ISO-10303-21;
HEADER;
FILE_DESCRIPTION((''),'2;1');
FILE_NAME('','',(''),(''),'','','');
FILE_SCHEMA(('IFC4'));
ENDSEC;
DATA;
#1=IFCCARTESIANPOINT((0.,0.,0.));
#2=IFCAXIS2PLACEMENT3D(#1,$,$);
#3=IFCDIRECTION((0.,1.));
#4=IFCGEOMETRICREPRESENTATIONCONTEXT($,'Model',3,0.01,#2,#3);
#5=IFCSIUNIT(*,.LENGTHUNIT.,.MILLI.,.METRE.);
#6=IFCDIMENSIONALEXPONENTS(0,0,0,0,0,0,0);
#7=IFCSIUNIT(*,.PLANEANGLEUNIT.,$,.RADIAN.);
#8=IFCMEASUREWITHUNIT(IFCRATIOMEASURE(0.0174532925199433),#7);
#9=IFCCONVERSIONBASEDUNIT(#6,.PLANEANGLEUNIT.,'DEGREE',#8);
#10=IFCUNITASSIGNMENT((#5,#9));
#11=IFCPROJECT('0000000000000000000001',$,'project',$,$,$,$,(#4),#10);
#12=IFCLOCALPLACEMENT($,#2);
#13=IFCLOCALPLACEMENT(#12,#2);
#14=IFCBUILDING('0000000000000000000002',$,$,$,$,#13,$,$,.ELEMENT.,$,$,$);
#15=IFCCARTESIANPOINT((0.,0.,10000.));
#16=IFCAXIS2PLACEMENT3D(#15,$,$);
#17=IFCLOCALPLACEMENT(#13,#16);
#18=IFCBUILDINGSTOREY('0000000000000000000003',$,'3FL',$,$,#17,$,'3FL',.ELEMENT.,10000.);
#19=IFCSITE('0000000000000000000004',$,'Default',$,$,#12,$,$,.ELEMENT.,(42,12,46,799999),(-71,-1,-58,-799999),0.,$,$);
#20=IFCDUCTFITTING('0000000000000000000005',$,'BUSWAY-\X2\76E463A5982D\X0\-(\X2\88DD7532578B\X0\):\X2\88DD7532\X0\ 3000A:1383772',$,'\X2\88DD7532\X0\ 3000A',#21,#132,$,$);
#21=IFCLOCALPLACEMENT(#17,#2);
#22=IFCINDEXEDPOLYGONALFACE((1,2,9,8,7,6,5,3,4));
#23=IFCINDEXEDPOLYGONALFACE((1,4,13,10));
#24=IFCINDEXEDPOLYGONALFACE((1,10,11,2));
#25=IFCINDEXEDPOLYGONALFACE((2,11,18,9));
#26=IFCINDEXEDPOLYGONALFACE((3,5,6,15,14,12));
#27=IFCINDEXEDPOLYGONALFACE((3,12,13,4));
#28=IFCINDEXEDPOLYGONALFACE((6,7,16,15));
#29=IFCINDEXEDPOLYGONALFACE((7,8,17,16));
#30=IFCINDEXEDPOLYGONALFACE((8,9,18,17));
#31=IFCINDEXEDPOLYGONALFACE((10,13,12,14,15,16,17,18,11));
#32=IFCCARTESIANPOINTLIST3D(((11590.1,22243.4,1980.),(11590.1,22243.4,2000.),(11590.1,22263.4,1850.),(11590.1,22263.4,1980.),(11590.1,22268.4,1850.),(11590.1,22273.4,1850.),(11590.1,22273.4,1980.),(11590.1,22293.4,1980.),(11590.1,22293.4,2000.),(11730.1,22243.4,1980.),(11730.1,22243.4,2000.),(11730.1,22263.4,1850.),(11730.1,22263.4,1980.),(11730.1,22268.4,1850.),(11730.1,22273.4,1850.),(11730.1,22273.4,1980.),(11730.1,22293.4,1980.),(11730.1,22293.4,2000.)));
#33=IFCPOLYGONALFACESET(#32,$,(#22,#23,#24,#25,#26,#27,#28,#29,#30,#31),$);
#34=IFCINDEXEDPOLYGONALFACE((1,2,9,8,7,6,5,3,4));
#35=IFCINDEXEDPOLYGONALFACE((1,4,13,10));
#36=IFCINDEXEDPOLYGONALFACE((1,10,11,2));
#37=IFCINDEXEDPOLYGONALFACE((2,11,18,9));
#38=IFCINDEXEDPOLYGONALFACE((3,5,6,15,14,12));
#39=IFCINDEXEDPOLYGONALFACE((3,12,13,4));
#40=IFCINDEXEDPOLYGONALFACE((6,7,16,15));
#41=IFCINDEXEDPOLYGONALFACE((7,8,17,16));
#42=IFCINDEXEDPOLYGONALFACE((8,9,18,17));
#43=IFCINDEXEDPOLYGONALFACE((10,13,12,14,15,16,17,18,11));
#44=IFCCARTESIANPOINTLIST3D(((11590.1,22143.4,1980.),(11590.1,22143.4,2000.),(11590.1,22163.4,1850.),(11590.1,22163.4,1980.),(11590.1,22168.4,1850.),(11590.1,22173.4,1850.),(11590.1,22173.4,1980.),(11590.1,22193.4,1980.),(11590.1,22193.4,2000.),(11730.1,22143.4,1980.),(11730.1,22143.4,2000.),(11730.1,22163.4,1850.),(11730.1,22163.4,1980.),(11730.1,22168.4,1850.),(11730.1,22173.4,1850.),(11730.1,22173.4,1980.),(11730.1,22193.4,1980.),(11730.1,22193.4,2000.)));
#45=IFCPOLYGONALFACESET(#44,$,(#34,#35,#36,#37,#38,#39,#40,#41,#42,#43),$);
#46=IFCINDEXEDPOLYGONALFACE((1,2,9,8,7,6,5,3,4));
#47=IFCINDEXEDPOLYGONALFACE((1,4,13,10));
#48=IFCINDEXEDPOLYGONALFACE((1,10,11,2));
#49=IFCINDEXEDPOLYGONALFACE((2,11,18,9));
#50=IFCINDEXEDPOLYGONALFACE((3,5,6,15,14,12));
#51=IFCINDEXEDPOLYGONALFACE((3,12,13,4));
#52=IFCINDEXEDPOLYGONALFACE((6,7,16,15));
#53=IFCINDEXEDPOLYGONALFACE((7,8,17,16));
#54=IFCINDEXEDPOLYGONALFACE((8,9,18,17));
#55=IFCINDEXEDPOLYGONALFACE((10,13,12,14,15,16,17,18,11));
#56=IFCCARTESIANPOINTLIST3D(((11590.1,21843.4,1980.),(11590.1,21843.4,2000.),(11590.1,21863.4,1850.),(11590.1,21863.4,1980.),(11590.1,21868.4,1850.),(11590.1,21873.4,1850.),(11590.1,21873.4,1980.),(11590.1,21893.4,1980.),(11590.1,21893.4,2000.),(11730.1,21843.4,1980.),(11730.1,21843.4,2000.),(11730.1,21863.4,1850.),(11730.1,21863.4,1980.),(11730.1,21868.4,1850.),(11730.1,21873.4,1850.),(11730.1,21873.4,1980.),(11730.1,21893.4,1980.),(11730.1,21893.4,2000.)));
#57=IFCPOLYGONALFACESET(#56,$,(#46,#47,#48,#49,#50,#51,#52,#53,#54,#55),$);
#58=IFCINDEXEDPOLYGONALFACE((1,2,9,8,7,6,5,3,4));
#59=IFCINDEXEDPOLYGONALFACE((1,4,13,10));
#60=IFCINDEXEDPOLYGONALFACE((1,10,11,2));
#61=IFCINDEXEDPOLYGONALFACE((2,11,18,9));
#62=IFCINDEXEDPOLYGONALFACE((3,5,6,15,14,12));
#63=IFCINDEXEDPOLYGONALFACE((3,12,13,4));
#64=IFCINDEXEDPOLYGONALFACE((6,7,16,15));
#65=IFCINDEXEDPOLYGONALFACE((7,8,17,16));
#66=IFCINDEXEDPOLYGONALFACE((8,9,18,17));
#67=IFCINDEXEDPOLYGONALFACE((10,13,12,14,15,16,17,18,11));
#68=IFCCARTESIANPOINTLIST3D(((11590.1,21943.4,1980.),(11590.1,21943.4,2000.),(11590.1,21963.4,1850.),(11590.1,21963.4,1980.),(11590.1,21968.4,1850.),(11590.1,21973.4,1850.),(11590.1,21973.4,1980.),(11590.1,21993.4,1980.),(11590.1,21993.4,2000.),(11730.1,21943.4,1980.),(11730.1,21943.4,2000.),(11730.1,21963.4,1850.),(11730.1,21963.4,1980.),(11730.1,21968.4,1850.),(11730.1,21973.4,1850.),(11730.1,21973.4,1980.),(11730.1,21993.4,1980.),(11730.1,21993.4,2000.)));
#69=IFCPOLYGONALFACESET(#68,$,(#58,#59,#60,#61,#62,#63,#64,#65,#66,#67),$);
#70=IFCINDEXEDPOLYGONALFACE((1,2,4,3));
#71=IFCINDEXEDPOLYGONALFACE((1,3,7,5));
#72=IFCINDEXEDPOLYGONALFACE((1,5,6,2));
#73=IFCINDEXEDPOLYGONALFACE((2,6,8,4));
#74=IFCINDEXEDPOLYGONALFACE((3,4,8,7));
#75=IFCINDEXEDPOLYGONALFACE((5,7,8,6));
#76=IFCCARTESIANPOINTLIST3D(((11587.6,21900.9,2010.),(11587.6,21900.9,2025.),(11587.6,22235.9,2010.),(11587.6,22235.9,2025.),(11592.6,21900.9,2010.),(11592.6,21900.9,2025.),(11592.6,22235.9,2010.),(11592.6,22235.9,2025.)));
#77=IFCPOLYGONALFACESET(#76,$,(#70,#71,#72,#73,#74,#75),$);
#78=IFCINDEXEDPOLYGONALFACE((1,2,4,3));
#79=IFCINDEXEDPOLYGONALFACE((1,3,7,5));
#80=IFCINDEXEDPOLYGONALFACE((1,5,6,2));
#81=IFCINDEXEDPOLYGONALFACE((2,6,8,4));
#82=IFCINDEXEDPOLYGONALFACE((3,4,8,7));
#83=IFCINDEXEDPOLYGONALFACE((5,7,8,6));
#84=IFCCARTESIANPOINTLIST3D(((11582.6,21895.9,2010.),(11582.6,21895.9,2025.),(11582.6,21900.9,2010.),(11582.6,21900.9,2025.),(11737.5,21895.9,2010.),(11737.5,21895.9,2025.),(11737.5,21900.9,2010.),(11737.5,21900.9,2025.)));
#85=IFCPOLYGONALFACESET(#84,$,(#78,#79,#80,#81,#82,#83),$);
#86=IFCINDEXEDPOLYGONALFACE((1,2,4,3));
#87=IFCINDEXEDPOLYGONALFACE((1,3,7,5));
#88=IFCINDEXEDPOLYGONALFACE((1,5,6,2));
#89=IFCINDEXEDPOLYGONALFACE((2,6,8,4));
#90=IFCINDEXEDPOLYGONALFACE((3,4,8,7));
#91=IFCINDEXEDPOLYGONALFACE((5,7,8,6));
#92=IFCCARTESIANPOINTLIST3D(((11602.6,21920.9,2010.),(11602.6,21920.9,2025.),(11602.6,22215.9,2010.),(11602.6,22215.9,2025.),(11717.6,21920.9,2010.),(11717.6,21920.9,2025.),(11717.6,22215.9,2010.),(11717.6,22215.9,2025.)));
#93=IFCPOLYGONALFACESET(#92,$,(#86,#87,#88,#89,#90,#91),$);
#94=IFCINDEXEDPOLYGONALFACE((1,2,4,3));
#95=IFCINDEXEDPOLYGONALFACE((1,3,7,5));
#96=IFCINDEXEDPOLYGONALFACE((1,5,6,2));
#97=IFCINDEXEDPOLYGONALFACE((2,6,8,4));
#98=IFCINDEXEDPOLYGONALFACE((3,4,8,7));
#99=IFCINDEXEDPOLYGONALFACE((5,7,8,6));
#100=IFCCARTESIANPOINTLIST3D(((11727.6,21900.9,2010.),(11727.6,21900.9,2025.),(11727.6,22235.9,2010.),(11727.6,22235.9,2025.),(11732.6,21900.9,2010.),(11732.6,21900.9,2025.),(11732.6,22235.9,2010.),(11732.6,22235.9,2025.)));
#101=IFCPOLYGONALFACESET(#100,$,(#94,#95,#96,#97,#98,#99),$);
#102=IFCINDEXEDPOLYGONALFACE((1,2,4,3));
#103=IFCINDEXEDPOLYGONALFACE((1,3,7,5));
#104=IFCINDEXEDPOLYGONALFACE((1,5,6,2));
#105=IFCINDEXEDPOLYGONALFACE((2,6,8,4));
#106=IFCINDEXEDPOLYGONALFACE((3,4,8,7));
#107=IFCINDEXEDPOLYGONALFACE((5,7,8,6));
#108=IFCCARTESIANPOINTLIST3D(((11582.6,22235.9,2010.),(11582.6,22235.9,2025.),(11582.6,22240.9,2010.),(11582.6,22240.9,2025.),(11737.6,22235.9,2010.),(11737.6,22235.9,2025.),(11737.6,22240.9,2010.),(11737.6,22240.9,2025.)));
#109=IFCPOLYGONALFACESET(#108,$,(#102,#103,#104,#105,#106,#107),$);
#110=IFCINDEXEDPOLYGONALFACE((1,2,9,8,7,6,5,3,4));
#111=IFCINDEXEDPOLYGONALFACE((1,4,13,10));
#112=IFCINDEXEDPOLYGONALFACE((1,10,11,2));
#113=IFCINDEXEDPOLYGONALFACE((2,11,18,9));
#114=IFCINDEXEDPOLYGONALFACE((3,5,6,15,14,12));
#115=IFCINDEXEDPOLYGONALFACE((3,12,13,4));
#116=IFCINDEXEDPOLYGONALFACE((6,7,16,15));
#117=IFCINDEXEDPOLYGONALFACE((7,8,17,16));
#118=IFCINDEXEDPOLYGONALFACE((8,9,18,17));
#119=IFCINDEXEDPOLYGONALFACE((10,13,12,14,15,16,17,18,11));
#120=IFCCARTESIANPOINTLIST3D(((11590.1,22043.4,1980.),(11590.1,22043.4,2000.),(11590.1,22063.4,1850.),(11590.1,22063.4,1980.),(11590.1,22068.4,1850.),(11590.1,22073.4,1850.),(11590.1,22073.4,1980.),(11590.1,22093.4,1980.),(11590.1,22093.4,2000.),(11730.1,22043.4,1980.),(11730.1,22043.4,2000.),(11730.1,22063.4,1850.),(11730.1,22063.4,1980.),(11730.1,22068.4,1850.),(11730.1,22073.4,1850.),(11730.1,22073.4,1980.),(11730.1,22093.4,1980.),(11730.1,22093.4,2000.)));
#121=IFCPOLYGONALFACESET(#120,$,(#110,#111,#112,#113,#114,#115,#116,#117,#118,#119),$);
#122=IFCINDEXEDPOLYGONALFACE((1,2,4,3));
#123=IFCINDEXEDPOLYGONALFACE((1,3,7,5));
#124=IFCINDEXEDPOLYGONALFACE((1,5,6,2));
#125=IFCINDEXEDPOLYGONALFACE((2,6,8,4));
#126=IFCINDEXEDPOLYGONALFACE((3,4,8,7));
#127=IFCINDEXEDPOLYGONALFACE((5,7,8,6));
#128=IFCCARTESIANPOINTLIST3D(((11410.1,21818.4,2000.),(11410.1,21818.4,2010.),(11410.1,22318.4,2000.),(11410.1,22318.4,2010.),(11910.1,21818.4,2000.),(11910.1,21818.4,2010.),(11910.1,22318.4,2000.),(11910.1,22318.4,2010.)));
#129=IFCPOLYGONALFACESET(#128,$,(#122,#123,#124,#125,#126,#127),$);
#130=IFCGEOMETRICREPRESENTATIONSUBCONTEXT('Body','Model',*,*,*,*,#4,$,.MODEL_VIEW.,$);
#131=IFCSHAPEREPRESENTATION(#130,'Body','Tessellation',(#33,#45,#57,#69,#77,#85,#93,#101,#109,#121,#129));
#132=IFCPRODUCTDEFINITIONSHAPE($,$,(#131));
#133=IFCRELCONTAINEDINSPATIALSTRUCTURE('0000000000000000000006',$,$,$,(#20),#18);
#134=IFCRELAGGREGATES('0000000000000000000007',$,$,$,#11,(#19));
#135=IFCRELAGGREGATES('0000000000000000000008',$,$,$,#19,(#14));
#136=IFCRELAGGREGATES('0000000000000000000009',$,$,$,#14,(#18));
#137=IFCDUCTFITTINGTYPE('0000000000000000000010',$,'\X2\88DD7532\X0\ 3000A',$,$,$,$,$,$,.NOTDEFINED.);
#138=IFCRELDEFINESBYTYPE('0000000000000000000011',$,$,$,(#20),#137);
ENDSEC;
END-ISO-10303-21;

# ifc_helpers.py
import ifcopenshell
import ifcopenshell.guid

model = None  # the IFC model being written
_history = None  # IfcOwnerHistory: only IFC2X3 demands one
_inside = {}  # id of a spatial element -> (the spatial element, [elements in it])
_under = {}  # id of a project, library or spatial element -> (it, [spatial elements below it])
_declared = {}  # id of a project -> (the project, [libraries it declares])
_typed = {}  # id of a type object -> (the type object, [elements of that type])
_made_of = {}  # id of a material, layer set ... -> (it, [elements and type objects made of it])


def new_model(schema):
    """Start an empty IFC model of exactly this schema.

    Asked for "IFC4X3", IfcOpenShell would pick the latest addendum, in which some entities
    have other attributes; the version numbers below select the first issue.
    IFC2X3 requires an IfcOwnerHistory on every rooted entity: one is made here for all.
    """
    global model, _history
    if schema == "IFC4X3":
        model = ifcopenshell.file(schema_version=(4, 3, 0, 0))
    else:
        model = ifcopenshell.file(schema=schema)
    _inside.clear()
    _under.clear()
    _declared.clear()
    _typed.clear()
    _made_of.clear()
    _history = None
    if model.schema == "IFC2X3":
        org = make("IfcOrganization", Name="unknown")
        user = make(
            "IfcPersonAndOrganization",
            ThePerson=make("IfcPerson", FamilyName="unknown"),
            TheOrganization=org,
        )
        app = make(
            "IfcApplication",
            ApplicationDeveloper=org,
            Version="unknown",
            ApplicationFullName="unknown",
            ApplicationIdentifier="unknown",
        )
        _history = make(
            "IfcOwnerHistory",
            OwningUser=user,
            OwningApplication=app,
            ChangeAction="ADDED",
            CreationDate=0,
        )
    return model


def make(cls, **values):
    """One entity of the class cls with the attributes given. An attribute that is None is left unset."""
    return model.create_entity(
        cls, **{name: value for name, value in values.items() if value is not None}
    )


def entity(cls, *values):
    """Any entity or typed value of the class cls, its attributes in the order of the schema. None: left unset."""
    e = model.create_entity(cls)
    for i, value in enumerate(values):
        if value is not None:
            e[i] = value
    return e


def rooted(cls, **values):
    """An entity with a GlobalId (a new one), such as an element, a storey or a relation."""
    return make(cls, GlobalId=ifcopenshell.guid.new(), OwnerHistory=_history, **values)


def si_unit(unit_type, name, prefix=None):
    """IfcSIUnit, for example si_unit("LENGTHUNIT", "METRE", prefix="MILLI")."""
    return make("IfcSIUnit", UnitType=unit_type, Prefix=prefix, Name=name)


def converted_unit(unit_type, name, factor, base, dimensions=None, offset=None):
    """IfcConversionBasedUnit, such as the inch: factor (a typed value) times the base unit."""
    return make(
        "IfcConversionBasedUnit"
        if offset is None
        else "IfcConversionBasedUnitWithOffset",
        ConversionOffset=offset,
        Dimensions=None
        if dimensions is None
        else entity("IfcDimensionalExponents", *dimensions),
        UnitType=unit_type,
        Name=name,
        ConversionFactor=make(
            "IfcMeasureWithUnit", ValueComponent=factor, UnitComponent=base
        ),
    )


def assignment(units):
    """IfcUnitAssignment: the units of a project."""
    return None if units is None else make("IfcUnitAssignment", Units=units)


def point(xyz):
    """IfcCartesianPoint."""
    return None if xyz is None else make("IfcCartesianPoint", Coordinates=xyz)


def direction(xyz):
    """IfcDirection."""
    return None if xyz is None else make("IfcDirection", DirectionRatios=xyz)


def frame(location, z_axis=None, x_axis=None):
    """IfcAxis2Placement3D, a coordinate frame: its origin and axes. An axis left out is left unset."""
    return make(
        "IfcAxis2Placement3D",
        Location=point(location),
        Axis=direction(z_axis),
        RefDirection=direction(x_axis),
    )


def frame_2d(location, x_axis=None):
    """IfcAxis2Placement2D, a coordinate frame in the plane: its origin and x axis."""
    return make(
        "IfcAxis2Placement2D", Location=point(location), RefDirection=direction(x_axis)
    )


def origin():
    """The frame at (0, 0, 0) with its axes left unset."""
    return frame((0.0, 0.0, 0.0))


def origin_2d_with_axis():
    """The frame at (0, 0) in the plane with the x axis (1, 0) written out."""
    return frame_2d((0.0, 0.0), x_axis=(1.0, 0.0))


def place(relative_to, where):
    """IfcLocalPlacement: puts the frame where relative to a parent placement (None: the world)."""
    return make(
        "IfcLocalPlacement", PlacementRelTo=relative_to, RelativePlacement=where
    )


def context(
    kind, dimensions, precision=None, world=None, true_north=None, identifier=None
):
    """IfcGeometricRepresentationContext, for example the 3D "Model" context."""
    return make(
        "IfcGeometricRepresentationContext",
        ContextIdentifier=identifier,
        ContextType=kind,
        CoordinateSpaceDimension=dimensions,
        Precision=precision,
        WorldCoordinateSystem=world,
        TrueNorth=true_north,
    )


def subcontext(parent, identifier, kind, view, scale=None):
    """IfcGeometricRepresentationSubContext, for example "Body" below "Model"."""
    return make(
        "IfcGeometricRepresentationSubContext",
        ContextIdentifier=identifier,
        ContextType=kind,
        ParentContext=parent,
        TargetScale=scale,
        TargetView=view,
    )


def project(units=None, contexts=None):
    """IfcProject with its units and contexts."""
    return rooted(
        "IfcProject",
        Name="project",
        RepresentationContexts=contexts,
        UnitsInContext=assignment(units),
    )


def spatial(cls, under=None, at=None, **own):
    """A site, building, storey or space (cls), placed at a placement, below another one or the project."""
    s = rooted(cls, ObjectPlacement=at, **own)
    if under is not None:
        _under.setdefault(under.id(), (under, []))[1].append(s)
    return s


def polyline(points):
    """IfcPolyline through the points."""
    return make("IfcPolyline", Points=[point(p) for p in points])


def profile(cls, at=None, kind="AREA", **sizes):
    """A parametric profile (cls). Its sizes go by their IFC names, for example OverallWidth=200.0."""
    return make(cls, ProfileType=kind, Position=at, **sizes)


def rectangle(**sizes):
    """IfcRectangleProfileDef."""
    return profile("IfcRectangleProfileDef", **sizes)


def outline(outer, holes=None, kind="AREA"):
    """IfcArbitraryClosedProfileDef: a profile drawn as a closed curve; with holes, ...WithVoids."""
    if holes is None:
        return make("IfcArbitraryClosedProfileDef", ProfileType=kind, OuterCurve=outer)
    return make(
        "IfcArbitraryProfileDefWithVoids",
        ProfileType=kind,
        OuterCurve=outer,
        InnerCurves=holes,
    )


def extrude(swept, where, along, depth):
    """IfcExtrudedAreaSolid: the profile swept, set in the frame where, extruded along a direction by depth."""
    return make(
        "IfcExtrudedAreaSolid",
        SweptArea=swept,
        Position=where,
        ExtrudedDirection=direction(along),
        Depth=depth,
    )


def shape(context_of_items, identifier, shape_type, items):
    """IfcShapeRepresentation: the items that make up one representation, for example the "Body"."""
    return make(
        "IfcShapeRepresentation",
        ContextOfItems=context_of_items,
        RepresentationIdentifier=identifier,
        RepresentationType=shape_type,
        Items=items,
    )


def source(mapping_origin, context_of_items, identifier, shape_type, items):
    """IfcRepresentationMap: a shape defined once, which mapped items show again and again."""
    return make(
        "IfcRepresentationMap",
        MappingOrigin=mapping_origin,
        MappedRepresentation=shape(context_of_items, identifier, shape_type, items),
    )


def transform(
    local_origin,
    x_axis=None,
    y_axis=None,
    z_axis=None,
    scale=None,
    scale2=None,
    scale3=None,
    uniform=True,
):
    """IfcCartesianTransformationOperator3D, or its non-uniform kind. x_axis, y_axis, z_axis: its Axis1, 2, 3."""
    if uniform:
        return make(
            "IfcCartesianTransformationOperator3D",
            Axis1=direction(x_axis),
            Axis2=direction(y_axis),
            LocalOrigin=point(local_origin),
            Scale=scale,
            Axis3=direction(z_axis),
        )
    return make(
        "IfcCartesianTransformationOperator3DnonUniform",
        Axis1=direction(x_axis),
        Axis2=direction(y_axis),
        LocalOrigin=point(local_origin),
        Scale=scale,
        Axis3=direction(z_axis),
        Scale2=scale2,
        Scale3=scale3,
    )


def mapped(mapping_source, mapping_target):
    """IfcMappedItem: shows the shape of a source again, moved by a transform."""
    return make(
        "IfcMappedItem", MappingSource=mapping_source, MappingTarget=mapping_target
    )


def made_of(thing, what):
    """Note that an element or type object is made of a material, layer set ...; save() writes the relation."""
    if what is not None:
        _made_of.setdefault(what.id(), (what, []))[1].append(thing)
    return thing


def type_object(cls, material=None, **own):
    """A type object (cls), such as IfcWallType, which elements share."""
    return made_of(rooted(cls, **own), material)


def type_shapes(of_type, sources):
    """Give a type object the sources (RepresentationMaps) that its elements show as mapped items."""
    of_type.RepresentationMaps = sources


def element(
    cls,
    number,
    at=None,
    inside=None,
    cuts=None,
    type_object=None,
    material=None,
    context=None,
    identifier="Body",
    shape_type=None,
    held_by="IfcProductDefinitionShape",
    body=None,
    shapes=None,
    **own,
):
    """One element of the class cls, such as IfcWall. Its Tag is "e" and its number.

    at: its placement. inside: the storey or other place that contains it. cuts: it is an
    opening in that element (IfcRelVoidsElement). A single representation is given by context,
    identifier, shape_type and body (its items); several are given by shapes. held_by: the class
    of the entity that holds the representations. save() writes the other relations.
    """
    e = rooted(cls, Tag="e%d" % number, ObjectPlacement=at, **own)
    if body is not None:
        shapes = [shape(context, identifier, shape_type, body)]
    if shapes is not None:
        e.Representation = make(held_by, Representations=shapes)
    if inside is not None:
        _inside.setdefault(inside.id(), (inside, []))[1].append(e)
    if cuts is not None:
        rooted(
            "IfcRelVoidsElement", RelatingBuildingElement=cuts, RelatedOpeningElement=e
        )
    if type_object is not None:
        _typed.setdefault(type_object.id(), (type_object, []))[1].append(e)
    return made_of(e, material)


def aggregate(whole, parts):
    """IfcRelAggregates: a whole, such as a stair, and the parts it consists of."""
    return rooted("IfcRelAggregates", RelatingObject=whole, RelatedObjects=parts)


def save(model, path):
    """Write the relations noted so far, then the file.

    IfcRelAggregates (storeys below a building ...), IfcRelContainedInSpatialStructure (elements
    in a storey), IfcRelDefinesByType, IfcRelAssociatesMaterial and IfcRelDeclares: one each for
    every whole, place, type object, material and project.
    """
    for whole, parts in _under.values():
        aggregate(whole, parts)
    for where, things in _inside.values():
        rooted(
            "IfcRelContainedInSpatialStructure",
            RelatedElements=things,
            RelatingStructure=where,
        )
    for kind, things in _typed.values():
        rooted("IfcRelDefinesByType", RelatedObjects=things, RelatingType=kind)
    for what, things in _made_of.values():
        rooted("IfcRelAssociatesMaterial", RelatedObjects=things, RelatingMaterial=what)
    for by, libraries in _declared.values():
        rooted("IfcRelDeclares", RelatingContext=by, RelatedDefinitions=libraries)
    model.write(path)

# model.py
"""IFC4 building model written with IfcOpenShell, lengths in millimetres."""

from ifc_helpers import new_model, entity, si_unit, converted_unit, direction, frame, frame_2d, origin, origin_2d_with_axis, place, context, subcontext, project, spatial, polyline, rectangle, outline, extrude, source, transform, mapped, type_object, type_shapes, element, save


model = new_model("IFC4")

# Units and contexts
model_context = context("Model", 3, precision=0.01, world=origin(), true_north=direction((0.0, 1.0)))
body_context = subcontext(model_context, "Body", "Model", "MODEL_VIEW")
ifc_project = project(units=[si_unit("LENGTHUNIT", "METRE", prefix="MILLI"), converted_unit("PLANEANGLEUNIT", "DEGREE", entity("IfcRatioMeasure", 0.0174532925199433), si_unit("PLANEANGLEUNIT", "RADIAN"), dimensions=[0, 0, 0, 0, 0, 0, 0])], contexts=[model_context])

# Site, building, storey
site_placement = place(None, origin())
site = spatial("IfcSite", under=ifc_project, at=site_placement, Name="Default", CompositionType="ELEMENT", RefLatitude=(42, 12, 46, 799999), RefLongitude=(-71, -1, -58, -799999), RefElevation=0.0)
building_placement = place(site_placement, origin())
building = spatial("IfcBuilding", under=site, at=building_placement, CompositionType="ELEMENT")
storey_placement = place(building_placement, frame((0.0, 0.0, 10000.0)))
storey = spatial("IfcBuildingStorey", under=building, at=storey_placement, Name="3FL", LongName="3FL", CompositionType="ELEMENT", Elevation=10000.0)

# Duct fitting
duct_fitting_type_1 = type_object("IfcDuctFittingType", Name="裝甲 3000A", PredefinedType="NOTDEFINED")
shared_shape_1 = source(origin(), body_context, "Body", "SweptSolid", [
    extrude(outline(polyline([(-25.0, -58.9), (25.0, -58.9), (25.0, -38.9), (5.0, -38.9), (5.0, 91.1), (0.0, 91.1), (-5.0, 91.1), (-5.0, -38.9), (-25.0, -38.9), (-25.0, -58.9)])), frame((-200.0, -70.0, -58.9), z_axis=(0.0, 1.0, 0.0), x_axis=(1.0, 0.0, 0.0)), (0.0, 0.0, 1.0), 140.0),
    extrude(outline(polyline([(-25.0, -58.9), (25.0, -58.9), (25.0, -38.9), (5.0, -38.9), (5.0, 91.1), (0.0, 91.1), (-5.0, 91.1), (-5.0, -38.9), (-25.0, -38.9), (-25.0, -58.9)])), frame((-100.0, -70.0, -58.9), z_axis=(0.0, 1.0, 0.0), x_axis=(1.0, 0.0, 0.0)), (0.0, 0.0, 1.0), 140.0),
    extrude(outline(polyline([(-58.9, -25.0), (-38.9, -25.0), (-38.9, -5.0), (91.1, -5.0), (91.1, 0.0), (91.1, 5.0), (-38.9, 5.0), (-38.9, 25.0), (-58.9, 25.0), (-58.9, -25.0)])), frame((200.0, -70.0, -58.9), z_axis=(0.0, 1.0, 0.0), x_axis=(0.0, 0.0, -1.0)), (0.0, 0.0, 1.0), 140.0),
    extrude(outline(polyline([(-58.9, -25.0), (-38.9, -25.0), (-38.9, -5.0), (91.1, -5.0), (91.1, 0.0), (91.1, 5.0), (-38.9, 5.0), (-38.9, 25.0), (-58.9, 25.0), (-58.9, -25.0)])), frame((100.0, -70.0, -58.9), z_axis=(0.0, 1.0, 0.0), x_axis=(0.0, 0.0, -1.0)), (0.0, 0.0, 1.0), 140.0),
    extrude(rectangle(XDim=335.0, YDim=5.0, at=origin_2d_with_axis()), frame((0.0, -70.0, 10.0), z_axis=(0.0, 0.0, 1.0), x_axis=(-1.0, 0.0, 0.0)), (0.0, 0.0, 1.0), 15.0),
    extrude(rectangle(XDim=5.0, YDim=154.9, at=frame_2d((0.0, 0.0), x_axis=(1.0, 0.0))), frame((170.0, -0.1, 10.0), z_axis=(0.0, 0.0, 1.0), x_axis=(-1.0, 0.0, 0.0)), (0.0, 0.0, 1.0), 15.0),
    extrude(rectangle(XDim=295.0, YDim=115.0, at=origin_2d_with_axis()), frame((0.0, 0.0, 10.0), z_axis=(0.0, 0.0, 1.0), x_axis=(-1.0, 0.0, 0.0)), (0.0, 0.0, 1.0), 15.0),
    extrude(rectangle(XDim=335.0, YDim=5.0, at=origin_2d_with_axis()), frame((0.0, 70.0, 10.0), z_axis=(0.0, 0.0, 1.0), x_axis=(-1.0, 0.0, 0.0)), (0.0, 0.0, 1.0), 15.0),
    extrude(rectangle(XDim=5.0, YDim=155.0, at=origin_2d_with_axis()), frame((-170.0, 0.0, 10.0), z_axis=(0.0, 0.0, 1.0), x_axis=(-1.0, 0.0, 0.0)), (0.0, 0.0, 1.0), 15.0),
    extrude(outline(polyline([(-58.9, -25.0), (-38.9, -25.0), (-38.9, -5.0), (91.1, -5.0), (91.1, 0.0), (91.1, 5.0), (-38.9, 5.0), (-38.9, 25.0), (-58.9, 25.0), (-58.9, -25.0)])), frame((0.0, -70.0, -58.9), z_axis=(0.0, 1.0, 0.0), x_axis=(0.0, 0.0, -1.0)), (0.0, 0.0, 1.0), 140.0),
    extrude(rectangle(XDim=500.0, YDim=500.0, at=origin_2d_with_axis()), frame((0.0, 0.0, 0.0), z_axis=(0.0, 0.0, 1.0), x_axis=(0.0, 1.0, 0.0)), (0.0, 0.0, 1.0), 10.0),
])
type_shapes(duct_fitting_type_1, [shared_shape_1])
for number, where, z_axis, x_axis, name in (
    (1, (11660.1, 22068.4, 2000.0), (0.0, 0.0, 1.0), (0.0, -1.0, 0.0), "BUSWAY-盤接頭-(裝甲型):裝甲 3000A:1383772"),
):
    element("IfcDuctFitting", number, at=place(storey_placement, frame(where, z_axis=z_axis, x_axis=x_axis)), inside=storey, type_object=duct_fitting_type_1, Name=name, ObjectType="裝甲 3000A", context=body_context, shape_type="MappedRepresentation", body=[
        mapped(shared_shape_1, transform((0.0, 0.0, 0.0), scale=1.0)),
    ])

save(model, "model.ifc")
